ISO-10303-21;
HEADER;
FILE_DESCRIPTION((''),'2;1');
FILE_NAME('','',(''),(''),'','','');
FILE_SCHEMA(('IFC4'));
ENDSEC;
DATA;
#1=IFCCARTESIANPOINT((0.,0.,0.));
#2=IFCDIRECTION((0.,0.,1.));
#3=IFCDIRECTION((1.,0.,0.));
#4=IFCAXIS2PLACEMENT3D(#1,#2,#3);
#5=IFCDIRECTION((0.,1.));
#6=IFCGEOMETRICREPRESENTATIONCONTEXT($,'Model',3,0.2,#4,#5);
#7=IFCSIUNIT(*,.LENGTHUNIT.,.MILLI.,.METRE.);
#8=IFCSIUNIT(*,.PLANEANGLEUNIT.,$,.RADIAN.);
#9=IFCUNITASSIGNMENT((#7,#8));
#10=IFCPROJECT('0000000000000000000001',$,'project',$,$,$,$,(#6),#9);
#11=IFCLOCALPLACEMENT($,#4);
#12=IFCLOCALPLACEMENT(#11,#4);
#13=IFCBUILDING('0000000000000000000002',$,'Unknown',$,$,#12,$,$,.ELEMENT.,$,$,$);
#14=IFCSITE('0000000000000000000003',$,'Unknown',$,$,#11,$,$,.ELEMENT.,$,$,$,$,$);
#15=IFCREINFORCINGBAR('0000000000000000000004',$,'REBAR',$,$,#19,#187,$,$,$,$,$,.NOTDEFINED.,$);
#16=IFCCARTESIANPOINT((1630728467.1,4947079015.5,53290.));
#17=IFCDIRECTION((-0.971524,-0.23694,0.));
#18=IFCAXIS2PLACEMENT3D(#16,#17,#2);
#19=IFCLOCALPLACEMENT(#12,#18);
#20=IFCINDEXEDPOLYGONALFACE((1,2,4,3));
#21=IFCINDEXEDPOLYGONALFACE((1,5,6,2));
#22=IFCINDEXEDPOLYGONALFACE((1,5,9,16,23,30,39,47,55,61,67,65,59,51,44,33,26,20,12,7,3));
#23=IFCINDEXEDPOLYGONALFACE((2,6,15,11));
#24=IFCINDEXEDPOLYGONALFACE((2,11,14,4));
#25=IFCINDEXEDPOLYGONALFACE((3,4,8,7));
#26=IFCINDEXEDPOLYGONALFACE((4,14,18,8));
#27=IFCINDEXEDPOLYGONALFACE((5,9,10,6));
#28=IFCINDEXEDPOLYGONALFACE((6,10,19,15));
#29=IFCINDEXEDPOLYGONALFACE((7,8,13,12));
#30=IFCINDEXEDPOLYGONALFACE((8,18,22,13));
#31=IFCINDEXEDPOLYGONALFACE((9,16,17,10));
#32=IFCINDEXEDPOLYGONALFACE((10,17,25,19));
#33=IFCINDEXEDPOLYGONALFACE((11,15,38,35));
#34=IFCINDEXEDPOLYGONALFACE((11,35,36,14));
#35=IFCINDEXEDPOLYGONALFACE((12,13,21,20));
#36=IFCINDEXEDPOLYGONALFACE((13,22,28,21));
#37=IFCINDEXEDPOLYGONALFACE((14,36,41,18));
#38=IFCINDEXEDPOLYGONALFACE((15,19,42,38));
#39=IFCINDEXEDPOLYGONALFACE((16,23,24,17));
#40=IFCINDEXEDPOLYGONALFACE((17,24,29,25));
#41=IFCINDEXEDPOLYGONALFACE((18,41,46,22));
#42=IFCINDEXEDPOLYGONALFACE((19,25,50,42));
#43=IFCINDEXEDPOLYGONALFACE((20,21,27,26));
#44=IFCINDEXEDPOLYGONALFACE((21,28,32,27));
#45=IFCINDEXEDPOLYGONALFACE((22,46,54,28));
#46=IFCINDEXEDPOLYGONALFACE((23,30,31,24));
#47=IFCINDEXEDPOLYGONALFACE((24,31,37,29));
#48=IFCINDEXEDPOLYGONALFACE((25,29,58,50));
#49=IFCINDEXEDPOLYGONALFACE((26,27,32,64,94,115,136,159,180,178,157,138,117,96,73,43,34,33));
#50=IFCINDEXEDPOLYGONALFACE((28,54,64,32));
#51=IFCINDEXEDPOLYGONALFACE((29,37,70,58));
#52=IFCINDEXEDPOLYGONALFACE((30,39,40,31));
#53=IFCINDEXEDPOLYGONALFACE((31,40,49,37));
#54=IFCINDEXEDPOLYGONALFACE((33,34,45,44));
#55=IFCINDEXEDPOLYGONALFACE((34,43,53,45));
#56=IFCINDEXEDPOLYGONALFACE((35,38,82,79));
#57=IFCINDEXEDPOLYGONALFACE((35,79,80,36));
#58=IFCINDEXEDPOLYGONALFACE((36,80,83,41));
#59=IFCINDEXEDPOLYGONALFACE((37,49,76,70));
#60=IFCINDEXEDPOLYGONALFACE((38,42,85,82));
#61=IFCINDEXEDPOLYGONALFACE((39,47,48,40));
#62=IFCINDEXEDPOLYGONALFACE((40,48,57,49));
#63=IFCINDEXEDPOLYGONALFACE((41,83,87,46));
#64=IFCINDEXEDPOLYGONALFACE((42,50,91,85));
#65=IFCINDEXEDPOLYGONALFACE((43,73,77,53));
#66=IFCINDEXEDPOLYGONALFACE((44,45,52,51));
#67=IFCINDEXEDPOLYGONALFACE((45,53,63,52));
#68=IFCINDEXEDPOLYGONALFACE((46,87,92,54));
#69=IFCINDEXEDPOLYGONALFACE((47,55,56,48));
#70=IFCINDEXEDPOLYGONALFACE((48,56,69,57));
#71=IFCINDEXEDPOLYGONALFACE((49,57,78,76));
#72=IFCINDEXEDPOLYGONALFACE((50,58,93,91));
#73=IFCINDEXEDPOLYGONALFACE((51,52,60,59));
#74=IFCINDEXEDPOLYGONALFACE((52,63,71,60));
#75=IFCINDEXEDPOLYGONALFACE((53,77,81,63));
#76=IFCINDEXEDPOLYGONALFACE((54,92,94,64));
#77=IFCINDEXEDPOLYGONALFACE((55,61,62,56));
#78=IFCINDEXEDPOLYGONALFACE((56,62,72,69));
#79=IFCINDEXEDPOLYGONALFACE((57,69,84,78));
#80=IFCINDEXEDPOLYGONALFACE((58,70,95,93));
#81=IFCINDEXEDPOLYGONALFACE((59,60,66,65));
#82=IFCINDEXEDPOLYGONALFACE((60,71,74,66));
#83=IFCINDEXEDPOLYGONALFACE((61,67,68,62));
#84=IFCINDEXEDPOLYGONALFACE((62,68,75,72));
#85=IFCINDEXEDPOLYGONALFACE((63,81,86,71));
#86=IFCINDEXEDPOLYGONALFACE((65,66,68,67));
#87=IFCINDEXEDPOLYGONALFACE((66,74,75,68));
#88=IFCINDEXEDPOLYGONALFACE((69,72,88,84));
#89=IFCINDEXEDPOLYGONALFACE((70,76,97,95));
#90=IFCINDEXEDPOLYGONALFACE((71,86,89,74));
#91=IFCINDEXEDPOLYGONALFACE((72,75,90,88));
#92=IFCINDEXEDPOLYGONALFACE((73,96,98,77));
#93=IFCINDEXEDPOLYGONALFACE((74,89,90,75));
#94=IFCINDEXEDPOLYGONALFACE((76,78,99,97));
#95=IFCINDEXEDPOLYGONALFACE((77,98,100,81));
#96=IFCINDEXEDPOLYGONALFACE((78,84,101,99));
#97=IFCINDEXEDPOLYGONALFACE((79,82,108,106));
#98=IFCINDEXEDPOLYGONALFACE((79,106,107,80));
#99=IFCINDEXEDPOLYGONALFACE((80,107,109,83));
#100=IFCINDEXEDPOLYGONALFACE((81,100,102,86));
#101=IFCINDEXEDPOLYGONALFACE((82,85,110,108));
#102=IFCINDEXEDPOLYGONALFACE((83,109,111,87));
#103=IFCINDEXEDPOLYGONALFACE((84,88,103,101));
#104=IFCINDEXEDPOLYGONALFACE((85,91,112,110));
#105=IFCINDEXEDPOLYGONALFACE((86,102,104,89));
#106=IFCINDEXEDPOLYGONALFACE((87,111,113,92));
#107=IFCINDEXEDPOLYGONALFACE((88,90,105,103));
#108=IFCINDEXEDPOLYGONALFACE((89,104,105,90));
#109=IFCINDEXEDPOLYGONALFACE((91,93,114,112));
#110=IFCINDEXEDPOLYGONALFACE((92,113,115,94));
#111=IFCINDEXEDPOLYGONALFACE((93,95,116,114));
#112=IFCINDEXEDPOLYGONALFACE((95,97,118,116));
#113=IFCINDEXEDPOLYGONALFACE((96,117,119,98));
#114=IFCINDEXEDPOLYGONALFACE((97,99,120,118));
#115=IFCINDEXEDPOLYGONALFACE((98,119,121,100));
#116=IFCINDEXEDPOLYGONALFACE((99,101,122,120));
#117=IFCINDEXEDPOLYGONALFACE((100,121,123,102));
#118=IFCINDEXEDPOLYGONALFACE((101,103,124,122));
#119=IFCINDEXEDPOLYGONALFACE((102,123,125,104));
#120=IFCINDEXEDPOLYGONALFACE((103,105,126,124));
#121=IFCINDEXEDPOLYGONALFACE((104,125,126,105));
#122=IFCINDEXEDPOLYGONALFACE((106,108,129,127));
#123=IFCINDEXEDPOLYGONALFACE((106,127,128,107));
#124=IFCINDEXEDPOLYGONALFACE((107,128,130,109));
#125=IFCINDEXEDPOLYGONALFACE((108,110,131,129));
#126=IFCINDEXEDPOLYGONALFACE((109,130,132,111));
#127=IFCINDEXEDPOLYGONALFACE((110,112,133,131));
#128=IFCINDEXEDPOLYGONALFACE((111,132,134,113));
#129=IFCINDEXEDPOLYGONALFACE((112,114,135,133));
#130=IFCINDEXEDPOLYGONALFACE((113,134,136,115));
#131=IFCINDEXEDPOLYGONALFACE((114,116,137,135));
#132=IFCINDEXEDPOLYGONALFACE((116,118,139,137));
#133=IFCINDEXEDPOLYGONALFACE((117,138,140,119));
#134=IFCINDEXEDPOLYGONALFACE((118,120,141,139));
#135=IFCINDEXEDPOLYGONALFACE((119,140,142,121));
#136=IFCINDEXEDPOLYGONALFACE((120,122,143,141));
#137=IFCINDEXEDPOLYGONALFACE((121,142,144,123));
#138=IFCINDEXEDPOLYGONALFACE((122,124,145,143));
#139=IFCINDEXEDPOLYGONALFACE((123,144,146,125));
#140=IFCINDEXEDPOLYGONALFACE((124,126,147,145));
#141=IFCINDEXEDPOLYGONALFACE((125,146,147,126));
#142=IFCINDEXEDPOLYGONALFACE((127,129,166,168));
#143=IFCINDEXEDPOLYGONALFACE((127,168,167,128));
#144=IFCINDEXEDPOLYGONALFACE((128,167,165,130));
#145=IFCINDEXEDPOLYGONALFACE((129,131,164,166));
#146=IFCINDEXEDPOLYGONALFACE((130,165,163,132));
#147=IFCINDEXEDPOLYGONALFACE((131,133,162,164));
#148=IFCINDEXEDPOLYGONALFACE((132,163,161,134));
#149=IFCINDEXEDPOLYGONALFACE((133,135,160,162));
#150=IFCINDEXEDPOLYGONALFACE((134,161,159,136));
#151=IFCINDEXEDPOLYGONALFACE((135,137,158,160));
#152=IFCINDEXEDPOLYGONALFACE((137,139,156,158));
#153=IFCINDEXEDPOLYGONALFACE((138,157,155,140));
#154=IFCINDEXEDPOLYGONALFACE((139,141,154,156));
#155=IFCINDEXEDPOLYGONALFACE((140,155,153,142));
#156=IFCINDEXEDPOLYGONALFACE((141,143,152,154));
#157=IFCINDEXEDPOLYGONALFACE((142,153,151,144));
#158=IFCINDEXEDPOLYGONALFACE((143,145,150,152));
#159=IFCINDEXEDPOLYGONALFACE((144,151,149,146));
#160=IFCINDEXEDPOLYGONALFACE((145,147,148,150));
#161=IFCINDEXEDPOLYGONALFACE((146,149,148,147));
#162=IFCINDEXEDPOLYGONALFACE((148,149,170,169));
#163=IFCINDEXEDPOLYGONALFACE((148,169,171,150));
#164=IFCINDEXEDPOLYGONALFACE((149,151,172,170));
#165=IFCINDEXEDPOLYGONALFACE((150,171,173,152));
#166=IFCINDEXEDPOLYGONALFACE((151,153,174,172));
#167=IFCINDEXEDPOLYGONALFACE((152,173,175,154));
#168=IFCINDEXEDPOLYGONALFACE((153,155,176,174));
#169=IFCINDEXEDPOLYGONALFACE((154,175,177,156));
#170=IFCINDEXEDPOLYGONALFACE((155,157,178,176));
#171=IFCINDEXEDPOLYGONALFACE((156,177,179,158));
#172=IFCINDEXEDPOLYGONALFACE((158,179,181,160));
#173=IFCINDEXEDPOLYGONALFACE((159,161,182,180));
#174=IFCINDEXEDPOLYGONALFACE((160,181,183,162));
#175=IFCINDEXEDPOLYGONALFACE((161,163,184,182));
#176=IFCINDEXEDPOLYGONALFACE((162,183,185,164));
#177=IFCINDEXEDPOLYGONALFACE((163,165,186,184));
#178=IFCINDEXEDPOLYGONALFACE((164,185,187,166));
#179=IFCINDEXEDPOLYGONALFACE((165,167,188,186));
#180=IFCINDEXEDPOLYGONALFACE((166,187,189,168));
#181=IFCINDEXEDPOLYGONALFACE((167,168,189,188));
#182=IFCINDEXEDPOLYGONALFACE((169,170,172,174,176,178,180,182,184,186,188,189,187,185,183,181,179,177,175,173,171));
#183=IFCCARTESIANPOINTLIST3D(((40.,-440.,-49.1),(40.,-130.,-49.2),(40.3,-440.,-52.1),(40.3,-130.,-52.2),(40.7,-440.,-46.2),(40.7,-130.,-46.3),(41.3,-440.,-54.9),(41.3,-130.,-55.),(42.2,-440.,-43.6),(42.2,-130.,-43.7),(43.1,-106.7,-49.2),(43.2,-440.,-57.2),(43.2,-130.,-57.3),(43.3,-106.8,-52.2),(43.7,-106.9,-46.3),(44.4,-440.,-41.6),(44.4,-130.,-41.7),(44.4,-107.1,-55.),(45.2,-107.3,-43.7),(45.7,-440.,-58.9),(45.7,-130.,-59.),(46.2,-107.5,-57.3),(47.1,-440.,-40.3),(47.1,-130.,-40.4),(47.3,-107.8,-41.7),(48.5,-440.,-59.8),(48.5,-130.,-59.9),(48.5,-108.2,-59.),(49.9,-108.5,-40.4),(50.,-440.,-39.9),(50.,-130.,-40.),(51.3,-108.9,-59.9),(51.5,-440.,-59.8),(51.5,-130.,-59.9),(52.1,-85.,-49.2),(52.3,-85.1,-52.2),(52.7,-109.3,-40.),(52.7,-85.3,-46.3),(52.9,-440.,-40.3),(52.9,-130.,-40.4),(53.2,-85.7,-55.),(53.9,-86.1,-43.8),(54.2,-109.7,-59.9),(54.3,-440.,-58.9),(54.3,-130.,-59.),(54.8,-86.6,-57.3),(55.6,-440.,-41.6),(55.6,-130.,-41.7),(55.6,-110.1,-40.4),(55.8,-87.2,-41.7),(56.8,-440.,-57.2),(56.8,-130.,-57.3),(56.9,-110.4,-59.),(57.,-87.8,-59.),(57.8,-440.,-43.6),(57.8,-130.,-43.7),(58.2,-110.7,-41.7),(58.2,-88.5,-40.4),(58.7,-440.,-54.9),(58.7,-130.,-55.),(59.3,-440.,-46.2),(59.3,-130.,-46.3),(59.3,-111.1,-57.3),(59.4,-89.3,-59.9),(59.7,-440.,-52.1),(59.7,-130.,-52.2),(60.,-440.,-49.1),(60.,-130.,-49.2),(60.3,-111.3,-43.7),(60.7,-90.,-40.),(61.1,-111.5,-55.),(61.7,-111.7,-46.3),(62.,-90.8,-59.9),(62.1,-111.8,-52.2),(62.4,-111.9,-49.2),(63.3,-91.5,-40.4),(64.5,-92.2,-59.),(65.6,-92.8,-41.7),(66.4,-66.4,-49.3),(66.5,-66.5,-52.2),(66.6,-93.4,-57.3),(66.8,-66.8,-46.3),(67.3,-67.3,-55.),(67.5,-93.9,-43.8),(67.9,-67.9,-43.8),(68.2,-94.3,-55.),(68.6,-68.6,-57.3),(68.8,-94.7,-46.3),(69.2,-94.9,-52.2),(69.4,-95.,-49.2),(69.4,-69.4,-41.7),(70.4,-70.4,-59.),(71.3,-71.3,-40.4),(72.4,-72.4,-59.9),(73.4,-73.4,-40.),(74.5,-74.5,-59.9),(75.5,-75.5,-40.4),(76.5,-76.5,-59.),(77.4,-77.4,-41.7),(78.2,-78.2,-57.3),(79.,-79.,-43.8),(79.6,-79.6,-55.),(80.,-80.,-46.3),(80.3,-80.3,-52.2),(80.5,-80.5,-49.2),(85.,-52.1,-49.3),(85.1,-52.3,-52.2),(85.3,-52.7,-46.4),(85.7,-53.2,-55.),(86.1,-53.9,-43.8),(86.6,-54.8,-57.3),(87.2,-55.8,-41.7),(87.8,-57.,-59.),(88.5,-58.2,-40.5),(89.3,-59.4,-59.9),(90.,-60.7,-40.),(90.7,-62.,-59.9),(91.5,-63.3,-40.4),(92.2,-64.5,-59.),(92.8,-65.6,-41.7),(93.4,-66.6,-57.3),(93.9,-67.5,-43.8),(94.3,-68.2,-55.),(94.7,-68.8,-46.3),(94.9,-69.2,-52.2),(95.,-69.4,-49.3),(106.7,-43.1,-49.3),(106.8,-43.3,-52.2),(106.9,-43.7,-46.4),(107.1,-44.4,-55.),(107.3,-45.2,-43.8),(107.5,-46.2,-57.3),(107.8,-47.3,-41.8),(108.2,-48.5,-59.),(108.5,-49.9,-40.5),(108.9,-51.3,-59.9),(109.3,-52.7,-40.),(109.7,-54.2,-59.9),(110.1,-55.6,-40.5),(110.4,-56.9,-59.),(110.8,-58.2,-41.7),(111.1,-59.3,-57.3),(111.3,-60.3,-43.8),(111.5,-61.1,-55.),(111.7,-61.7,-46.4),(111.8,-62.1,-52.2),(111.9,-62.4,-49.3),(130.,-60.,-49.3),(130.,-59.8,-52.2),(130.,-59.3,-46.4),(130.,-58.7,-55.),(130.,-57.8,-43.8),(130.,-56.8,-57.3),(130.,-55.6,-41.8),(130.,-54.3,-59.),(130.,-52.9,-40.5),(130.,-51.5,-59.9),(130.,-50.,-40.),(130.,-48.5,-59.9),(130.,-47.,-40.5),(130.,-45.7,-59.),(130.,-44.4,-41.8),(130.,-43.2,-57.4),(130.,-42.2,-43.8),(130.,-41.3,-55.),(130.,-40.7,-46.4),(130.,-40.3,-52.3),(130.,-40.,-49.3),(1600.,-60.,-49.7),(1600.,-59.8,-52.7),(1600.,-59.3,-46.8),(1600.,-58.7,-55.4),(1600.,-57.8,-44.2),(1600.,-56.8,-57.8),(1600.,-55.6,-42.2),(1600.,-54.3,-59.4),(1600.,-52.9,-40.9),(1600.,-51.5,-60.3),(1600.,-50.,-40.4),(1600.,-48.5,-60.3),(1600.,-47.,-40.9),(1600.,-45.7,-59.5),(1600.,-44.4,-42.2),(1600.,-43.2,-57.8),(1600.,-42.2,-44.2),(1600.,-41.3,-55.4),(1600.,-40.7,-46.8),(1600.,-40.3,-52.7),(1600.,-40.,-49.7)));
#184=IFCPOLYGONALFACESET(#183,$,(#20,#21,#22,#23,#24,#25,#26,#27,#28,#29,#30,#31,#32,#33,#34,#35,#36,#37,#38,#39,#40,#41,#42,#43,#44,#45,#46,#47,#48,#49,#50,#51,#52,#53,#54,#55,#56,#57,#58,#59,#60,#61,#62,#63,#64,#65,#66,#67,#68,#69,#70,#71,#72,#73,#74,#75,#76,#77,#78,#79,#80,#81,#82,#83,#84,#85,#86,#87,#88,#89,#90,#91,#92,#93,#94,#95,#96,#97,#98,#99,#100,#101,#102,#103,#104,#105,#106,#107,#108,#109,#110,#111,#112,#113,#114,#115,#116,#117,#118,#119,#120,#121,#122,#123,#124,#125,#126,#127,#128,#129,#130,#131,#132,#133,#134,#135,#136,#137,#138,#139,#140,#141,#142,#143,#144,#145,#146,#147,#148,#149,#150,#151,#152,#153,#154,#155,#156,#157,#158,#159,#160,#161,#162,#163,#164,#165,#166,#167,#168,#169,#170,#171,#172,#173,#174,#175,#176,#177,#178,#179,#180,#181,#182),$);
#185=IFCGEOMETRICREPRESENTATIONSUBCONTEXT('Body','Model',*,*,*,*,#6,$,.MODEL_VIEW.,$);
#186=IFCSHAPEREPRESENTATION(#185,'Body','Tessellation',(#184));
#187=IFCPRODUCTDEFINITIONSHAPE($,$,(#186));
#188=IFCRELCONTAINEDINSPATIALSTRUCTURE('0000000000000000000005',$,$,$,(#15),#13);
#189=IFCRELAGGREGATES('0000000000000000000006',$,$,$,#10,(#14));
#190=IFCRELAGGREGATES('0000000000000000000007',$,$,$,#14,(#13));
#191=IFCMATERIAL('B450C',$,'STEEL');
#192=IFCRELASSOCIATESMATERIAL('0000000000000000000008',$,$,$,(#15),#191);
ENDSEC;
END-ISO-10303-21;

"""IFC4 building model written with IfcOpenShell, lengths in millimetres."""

from ifc_helpers import new_model, entity, si_unit, direction, frame, origin_with_axes, place, context, subcontext, project, spatial, material, element, save


model = new_model("IFC4")

# Units and contexts
model_context = context("Model", 3, precision=0.2, world=origin_with_axes(), true_north=direction((0.0, 1.0)))
body_context = subcontext(model_context, "Body", "Model", "MODEL_VIEW")
ifc_project = project(units=[si_unit("LENGTHUNIT", "METRE", prefix="MILLI"), si_unit("PLANEANGLEUNIT", "RADIAN")], contexts=[model_context])

# Site, building
site_placement = place(None, origin_with_axes())
site = spatial("IfcSite", under=ifc_project, at=site_placement, Name="Unknown", CompositionType="ELEMENT")
building_placement = place(site_placement, origin_with_axes())
building = spatial("IfcBuilding", under=site, at=building_placement, Name="Unknown", CompositionType="ELEMENT")

# Reinforcing bar
ifc_material = material(Name="B450C", Category="STEEL")
reinforcing_bar_1_placement = place(building_placement, frame((1630728467.1, 4947079015.5, 53290.0), z_axis=(-0.971524, -0.23694, 0.0), x_axis=(0.0, 0.0, 1.0)))
element("IfcReinforcingBar", 1, at=reinforcing_bar_1_placement, inside=building, material=ifc_material, Name="REBAR", PredefinedType="NOTDEFINED", context=body_context, shape_type="AdvancedSweptSolid", body=[
    entity("IfcSweptDiskSolid", entity("IfcIndexedPolyCurve", entity("IfcCartesianPointList3D", [[50.0, -440.0, -49.9], [50.0, -130.0, -50.0], [73.4, -73.4, -50.0], [130.0, -50.0, -50.0], [1600.0, -50.0, -50.4]]), [entity("IfcLineIndex", [1, 2]), entity("IfcArcIndex", [2, 3, 4]), entity("IfcLineIndex", [4, 5])]), 10.0),
])

save(model, "model.ifc")
